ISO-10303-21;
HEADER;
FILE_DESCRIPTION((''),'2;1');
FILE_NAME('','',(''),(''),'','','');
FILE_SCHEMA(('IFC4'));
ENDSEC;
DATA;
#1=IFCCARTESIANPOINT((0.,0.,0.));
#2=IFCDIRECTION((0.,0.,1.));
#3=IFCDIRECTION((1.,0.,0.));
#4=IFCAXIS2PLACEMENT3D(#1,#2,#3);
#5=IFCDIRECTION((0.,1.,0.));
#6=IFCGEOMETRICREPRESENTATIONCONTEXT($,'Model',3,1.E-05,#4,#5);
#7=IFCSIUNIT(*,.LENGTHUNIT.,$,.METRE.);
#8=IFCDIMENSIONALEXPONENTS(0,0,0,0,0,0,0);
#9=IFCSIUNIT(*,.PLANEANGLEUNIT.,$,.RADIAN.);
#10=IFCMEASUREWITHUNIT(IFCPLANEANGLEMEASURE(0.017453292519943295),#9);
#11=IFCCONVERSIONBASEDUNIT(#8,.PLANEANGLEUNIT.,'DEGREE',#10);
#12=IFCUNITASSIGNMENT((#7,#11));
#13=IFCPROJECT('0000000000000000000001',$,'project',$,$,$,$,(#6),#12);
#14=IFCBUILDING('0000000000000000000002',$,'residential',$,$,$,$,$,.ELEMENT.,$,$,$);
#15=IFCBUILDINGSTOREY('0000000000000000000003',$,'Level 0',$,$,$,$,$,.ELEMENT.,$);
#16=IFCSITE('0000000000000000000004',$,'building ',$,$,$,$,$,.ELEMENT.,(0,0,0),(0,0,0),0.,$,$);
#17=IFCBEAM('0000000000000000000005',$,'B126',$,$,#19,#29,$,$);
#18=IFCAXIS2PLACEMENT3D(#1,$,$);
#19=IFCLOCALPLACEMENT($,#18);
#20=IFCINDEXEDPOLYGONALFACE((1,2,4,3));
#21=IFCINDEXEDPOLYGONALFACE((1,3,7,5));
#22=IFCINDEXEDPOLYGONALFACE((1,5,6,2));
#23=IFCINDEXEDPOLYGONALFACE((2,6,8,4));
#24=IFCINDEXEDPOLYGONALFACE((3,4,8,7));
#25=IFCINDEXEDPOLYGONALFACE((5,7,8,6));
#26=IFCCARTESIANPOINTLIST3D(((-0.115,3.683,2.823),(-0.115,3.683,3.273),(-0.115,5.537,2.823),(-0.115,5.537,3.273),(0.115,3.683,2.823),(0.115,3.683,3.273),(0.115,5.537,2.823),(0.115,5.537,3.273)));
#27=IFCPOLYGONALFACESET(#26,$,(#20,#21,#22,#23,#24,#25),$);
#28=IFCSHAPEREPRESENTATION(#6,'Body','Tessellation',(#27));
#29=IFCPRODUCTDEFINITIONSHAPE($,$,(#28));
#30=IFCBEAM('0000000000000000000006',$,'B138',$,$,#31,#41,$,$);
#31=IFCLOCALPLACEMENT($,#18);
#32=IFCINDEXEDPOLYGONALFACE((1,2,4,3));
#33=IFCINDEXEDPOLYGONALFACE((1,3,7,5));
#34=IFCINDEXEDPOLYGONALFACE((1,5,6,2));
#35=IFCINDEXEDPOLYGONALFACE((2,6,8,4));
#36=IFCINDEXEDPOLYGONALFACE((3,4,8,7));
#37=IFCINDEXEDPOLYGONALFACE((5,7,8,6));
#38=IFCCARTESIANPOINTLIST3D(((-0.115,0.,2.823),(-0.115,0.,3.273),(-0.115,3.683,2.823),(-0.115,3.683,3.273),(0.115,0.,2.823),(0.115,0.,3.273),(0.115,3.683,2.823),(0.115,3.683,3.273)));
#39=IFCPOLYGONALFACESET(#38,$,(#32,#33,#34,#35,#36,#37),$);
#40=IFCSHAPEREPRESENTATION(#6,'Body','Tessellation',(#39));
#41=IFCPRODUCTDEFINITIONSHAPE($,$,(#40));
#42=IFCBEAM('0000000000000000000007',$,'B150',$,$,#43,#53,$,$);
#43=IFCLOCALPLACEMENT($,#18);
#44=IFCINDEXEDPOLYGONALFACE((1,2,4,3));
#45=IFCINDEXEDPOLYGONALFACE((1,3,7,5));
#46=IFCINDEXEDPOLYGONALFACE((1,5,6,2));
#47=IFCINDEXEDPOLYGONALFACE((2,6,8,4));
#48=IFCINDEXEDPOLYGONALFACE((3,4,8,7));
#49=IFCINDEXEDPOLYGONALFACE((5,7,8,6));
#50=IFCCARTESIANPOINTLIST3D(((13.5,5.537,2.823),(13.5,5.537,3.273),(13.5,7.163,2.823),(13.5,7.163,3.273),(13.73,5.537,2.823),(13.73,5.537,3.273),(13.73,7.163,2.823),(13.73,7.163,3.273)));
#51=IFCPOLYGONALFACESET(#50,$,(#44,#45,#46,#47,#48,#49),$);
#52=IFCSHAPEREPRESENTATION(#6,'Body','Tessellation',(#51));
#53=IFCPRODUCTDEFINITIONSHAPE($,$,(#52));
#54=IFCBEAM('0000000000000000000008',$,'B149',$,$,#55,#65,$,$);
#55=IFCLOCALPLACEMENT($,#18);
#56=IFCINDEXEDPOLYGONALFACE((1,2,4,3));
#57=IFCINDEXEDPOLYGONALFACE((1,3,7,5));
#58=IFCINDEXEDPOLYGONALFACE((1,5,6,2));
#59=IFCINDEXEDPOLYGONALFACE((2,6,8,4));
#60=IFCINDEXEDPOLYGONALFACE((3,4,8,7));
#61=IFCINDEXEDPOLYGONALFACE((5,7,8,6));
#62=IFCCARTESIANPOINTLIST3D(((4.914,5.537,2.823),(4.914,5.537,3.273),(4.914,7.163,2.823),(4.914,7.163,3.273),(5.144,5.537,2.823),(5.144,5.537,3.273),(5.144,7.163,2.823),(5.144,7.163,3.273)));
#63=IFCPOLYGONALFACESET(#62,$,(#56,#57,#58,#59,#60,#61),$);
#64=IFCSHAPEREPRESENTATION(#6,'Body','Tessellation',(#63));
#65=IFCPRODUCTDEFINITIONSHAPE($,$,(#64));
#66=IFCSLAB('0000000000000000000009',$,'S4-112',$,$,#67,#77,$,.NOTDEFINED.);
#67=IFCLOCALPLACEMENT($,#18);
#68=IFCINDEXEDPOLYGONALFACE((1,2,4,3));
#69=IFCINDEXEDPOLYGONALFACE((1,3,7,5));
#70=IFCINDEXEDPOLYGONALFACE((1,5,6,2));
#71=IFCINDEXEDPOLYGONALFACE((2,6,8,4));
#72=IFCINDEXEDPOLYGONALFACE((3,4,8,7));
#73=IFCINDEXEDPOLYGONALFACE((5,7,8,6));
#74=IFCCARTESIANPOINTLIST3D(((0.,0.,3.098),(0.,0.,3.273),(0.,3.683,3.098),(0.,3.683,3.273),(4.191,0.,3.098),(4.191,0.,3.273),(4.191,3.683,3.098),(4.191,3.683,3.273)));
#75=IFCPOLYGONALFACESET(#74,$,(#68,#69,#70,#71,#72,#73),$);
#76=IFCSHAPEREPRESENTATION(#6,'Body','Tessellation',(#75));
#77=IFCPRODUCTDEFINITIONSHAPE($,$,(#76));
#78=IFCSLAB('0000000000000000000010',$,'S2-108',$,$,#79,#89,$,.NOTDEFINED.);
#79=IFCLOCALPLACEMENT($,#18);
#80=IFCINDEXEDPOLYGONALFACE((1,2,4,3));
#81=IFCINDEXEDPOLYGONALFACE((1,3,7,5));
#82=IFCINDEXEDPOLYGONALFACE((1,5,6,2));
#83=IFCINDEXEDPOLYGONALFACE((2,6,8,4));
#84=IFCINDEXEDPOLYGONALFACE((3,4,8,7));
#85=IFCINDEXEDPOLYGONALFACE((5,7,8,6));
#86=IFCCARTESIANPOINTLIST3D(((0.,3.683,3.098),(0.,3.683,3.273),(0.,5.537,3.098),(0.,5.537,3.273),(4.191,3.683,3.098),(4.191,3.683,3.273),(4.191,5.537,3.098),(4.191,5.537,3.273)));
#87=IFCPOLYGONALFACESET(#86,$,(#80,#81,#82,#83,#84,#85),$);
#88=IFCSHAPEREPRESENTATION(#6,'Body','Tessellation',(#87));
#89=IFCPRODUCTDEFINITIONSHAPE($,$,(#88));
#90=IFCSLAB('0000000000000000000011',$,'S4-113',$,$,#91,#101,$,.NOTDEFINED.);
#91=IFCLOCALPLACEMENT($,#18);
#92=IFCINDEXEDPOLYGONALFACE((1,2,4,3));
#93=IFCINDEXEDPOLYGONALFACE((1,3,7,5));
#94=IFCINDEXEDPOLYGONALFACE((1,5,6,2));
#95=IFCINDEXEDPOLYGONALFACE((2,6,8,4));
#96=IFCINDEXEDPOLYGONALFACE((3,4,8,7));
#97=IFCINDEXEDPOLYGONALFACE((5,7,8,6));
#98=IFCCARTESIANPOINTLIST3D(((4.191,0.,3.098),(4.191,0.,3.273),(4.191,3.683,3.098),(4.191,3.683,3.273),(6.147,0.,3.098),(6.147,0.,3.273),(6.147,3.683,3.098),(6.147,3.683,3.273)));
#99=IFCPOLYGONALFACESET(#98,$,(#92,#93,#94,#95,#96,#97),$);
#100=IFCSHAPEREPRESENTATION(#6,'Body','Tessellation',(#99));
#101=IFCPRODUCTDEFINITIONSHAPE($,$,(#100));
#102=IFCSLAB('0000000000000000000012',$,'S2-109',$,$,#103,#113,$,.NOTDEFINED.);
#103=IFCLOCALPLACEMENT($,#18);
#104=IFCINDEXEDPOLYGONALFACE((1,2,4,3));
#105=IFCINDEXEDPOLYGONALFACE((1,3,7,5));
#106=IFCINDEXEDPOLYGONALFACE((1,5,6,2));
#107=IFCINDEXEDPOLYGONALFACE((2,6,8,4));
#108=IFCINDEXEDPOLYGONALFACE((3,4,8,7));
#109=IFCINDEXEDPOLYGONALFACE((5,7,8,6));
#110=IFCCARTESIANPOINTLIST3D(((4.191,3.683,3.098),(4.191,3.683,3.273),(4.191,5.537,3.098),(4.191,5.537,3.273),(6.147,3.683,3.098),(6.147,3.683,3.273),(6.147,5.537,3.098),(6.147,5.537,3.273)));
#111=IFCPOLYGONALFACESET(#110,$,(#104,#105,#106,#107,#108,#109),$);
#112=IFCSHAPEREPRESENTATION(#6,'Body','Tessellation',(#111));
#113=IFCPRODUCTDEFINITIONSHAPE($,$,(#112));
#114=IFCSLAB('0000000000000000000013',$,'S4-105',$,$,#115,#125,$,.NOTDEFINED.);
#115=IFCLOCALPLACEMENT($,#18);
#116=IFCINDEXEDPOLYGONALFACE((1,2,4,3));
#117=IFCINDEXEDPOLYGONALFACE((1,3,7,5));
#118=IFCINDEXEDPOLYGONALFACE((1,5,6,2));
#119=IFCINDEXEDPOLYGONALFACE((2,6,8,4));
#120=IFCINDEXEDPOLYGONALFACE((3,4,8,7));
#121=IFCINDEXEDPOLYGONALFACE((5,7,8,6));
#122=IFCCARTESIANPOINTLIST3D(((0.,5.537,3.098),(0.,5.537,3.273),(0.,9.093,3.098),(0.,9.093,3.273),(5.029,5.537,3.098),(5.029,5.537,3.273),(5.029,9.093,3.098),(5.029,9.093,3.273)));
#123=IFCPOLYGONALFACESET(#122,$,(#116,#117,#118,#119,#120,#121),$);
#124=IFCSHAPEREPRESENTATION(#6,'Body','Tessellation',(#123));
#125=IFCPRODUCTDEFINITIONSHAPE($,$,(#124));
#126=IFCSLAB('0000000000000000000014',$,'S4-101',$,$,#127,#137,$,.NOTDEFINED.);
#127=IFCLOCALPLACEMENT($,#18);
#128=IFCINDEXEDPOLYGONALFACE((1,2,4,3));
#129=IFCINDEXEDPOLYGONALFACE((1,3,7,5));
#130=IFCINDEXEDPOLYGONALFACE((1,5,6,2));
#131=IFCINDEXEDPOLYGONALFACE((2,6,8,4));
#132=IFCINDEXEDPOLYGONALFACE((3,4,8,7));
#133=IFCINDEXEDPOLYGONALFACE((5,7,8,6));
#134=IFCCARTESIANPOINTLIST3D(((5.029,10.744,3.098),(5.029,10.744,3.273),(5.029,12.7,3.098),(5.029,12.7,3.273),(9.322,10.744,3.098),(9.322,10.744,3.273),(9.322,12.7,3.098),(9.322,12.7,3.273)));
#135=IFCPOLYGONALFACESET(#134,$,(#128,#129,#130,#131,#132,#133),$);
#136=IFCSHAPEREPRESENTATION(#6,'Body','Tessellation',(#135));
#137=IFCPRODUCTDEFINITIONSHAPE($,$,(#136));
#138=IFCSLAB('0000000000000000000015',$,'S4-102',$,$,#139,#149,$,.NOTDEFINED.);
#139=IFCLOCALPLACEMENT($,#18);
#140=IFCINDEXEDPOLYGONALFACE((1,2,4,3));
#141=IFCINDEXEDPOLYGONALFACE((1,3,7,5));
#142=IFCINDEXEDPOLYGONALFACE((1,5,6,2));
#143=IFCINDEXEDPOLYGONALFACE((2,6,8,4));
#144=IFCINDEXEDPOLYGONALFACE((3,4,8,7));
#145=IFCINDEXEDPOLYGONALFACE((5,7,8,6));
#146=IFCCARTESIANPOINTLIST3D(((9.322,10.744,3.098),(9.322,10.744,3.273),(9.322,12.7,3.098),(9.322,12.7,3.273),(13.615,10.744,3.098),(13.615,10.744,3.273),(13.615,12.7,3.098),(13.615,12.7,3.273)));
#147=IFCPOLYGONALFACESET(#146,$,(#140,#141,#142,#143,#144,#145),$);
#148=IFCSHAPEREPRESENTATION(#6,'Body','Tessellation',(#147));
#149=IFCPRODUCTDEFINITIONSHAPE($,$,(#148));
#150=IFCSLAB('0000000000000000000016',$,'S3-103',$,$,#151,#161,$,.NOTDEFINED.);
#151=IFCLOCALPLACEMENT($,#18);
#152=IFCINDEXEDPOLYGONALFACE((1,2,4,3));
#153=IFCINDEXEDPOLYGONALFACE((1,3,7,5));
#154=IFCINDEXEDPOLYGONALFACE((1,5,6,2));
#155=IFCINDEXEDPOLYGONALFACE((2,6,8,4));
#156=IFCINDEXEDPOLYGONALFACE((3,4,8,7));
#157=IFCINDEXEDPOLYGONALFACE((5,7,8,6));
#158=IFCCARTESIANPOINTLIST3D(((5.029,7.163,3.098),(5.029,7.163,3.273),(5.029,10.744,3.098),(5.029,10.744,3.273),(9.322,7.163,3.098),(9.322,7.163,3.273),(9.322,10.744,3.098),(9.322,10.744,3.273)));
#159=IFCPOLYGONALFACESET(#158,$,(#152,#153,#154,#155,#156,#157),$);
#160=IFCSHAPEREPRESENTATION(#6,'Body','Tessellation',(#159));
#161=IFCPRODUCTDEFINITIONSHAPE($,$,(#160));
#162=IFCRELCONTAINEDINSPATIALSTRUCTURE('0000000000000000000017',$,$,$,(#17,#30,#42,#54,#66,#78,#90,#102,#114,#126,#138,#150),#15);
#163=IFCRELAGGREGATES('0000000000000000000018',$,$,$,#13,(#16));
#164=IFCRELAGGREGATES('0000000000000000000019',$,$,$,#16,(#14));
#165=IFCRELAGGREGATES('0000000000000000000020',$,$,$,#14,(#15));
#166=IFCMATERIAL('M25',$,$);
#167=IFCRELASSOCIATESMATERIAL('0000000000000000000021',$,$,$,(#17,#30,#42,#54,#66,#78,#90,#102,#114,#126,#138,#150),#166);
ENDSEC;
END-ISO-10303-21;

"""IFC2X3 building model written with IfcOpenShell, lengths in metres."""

from ifc_helpers import new_model, entity, si_unit, converted_unit, direction, frame, frame_2d, origin_with_axes, place, context, project, spatial, rectangle, extrude, material, element, save


model = new_model("IFC2X3")

# Units and contexts
model_context = context("Model", 3, precision=1e-05, world=origin_with_axes(), true_north=direction((0.0, 1.0, 0.0)))
ifc_project = project(units=[si_unit("LENGTHUNIT", "METRE"), converted_unit("PLANEANGLEUNIT", "DEGREE", entity("IfcPlaneAngleMeasure", 0.017453292519943295), si_unit("PLANEANGLEUNIT", "RADIAN"), dimensions=[0, 0, 0, 0, 0, 0, 0])], contexts=[model_context])

# Site, building, storey
site = spatial("IfcSite", under=ifc_project, Name="building ", CompositionType="ELEMENT", RefLatitude=(0, 0, 0), RefLongitude=(0, 0, 0), RefElevation=0.0)
building = spatial("IfcBuilding", under=site, Name="residential", CompositionType="ELEMENT")
storey = spatial("IfcBuildingStorey", under=building, Name="Level 0", CompositionType="ELEMENT")

# Beams
ifc_material = material(Name="M25")
placement = place(None, origin_with_axes())
element("IfcBeam", 1, at=placement, inside=storey, material=ifc_material, Name="B126", context=model_context, shape_type="SweptSolid", body=[
    extrude(rectangle(XDim=0.23, YDim=0.45, at=frame_2d((0.0, 0.0), x_axis=(0.0, 1.0, 0.0))), frame((0.0, 3.683, 3.048), z_axis=(0.0, 1.0, 0.0), x_axis=(0.0, 0.0, -1.0)), (0.0, 0.0, 1.0), 1.854),
])
element("IfcBeam", 2, at=placement, inside=storey, material=ifc_material, Name="B138", context=model_context, shape_type="SweptSolid", body=[
    extrude(rectangle(XDim=0.23, YDim=0.45, at=frame_2d((0.0, 0.0), x_axis=(0.0, 1.0, 0.0))), frame((0.0, 0.0, 3.048), z_axis=(0.0, 1.0, 0.0), x_axis=(0.0, 0.0, -1.0)), (0.0, 0.0, 1.0), 3.683),
])
element("IfcBeam", 3, at=placement, inside=storey, material=ifc_material, Name="B150", context=model_context, shape_type="SweptSolid", body=[
    extrude(rectangle(XDim=0.23, YDim=0.45, at=frame_2d((0.0, 0.0), x_axis=(0.0, 1.0, 0.0))), frame((13.615, 5.537, 3.048), z_axis=(0.0, 1.0, 0.0), x_axis=(0.0, 0.0, -1.0)), (0.0, 0.0, 1.0), 1.626),
])
element("IfcBeam", 4, at=placement, inside=storey, material=ifc_material, Name="B149", context=model_context, shape_type="SweptSolid", body=[
    extrude(rectangle(XDim=0.23, YDim=0.45, at=frame_2d((0.0, 0.0), x_axis=(0.0, 1.0, 0.0))), frame((5.029, 5.537, 3.048), z_axis=(0.0, 1.0, 0.0), x_axis=(0.0, 0.0, -1.0)), (0.0, 0.0, 1.0), 1.626),
])

# Slabs
element("IfcSlab", 5, at=placement, inside=storey, material=ifc_material, Name="S4-112", PredefinedType="NOTDEFINED", context=model_context, shape_type="SweptSolid", body=[
    extrude(rectangle(XDim=4.191, YDim=3.683, at=frame_2d((0.0, 0.0), x_axis=(1.0, 0.0, 0.0))), frame((2.0955, 1.8415, 3.098), z_axis=(0.0, 0.0, 1.0), x_axis=(1.0, 0.0, 0.0)), (0.0, 0.0, 1.0), 0.175),
])
element("IfcSlab", 6, at=placement, inside=storey, material=ifc_material, Name="S2-108", PredefinedType="NOTDEFINED", context=model_context, shape_type="SweptSolid", body=[
    extrude(rectangle(XDim=4.191, YDim=1.854, at=frame_2d((0.0, 0.0), x_axis=(1.0, 0.0, 0.0))), frame((2.0955, 4.61, 3.098), z_axis=(0.0, 0.0, 1.0), x_axis=(1.0, 0.0, 0.0)), (0.0, 0.0, 1.0), 0.175),
])
element("IfcSlab", 7, at=placement, inside=storey, material=ifc_material, Name="S4-113", PredefinedType="NOTDEFINED", context=model_context, shape_type="SweptSolid", body=[
    extrude(rectangle(XDim=1.956, YDim=3.683, at=frame_2d((0.0, 0.0), x_axis=(1.0, 0.0, 0.0))), frame((5.169, 1.8415, 3.098), z_axis=(0.0, 0.0, 1.0), x_axis=(1.0, 0.0, 0.0)), (0.0, 0.0, 1.0), 0.175),
])
element("IfcSlab", 8, at=placement, inside=storey, material=ifc_material, Name="S2-109", PredefinedType="NOTDEFINED", context=model_context, shape_type="SweptSolid", body=[
    extrude(rectangle(XDim=1.956, YDim=1.854, at=frame_2d((0.0, 0.0), x_axis=(1.0, 0.0, 0.0))), frame((5.169, 4.61, 3.098), z_axis=(0.0, 0.0, 1.0), x_axis=(1.0, 0.0, 0.0)), (0.0, 0.0, 1.0), 0.175),
])
element("IfcSlab", 9, at=placement, inside=storey, material=ifc_material, Name="S4-105", PredefinedType="NOTDEFINED", context=model_context, shape_type="SweptSolid", body=[
    extrude(rectangle(XDim=5.029, YDim=3.556, at=frame_2d((0.0, 0.0), x_axis=(1.0, 0.0, 0.0))), frame((2.5145, 7.315, 3.098), z_axis=(0.0, 0.0, 1.0), x_axis=(1.0, 0.0, 0.0)), (0.0, 0.0, 1.0), 0.175),
])
element("IfcSlab", 10, at=placement, inside=storey, material=ifc_material, Name="S4-101", PredefinedType="NOTDEFINED", context=model_context, shape_type="SweptSolid", body=[
    extrude(rectangle(XDim=4.293, YDim=1.956, at=frame_2d((0.0, 0.0), x_axis=(1.0, 0.0, 0.0))), frame((7.1755, 11.722, 3.098), z_axis=(0.0, 0.0, 1.0), x_axis=(1.0, 0.0, 0.0)), (0.0, 0.0, 1.0), 0.175),
])
element("IfcSlab", 11, at=placement, inside=storey, material=ifc_material, Name="S4-102", PredefinedType="NOTDEFINED", context=model_context, shape_type="SweptSolid", body=[
    extrude(rectangle(XDim=4.293, YDim=1.956, at=frame_2d((0.0, 0.0), x_axis=(1.0, 0.0, 0.0))), frame((11.4685, 11.722, 3.098), z_axis=(0.0, 0.0, 1.0), x_axis=(1.0, 0.0, 0.0)), (0.0, 0.0, 1.0), 0.175),
])
element("IfcSlab", 12, at=placement, inside=storey, material=ifc_material, Name="S3-103", PredefinedType="NOTDEFINED", context=model_context, shape_type="SweptSolid", body=[
    extrude(rectangle(XDim=4.293, YDim=3.581, at=frame_2d((0.0, 0.0), x_axis=(1.0, 0.0, 0.0))), frame((7.1755, 8.9535, 3.098), z_axis=(0.0, 0.0, 1.0), x_axis=(1.0, 0.0, 0.0)), (0.0, 0.0, 1.0), 0.175),
])

save(model, "model.ifc")
